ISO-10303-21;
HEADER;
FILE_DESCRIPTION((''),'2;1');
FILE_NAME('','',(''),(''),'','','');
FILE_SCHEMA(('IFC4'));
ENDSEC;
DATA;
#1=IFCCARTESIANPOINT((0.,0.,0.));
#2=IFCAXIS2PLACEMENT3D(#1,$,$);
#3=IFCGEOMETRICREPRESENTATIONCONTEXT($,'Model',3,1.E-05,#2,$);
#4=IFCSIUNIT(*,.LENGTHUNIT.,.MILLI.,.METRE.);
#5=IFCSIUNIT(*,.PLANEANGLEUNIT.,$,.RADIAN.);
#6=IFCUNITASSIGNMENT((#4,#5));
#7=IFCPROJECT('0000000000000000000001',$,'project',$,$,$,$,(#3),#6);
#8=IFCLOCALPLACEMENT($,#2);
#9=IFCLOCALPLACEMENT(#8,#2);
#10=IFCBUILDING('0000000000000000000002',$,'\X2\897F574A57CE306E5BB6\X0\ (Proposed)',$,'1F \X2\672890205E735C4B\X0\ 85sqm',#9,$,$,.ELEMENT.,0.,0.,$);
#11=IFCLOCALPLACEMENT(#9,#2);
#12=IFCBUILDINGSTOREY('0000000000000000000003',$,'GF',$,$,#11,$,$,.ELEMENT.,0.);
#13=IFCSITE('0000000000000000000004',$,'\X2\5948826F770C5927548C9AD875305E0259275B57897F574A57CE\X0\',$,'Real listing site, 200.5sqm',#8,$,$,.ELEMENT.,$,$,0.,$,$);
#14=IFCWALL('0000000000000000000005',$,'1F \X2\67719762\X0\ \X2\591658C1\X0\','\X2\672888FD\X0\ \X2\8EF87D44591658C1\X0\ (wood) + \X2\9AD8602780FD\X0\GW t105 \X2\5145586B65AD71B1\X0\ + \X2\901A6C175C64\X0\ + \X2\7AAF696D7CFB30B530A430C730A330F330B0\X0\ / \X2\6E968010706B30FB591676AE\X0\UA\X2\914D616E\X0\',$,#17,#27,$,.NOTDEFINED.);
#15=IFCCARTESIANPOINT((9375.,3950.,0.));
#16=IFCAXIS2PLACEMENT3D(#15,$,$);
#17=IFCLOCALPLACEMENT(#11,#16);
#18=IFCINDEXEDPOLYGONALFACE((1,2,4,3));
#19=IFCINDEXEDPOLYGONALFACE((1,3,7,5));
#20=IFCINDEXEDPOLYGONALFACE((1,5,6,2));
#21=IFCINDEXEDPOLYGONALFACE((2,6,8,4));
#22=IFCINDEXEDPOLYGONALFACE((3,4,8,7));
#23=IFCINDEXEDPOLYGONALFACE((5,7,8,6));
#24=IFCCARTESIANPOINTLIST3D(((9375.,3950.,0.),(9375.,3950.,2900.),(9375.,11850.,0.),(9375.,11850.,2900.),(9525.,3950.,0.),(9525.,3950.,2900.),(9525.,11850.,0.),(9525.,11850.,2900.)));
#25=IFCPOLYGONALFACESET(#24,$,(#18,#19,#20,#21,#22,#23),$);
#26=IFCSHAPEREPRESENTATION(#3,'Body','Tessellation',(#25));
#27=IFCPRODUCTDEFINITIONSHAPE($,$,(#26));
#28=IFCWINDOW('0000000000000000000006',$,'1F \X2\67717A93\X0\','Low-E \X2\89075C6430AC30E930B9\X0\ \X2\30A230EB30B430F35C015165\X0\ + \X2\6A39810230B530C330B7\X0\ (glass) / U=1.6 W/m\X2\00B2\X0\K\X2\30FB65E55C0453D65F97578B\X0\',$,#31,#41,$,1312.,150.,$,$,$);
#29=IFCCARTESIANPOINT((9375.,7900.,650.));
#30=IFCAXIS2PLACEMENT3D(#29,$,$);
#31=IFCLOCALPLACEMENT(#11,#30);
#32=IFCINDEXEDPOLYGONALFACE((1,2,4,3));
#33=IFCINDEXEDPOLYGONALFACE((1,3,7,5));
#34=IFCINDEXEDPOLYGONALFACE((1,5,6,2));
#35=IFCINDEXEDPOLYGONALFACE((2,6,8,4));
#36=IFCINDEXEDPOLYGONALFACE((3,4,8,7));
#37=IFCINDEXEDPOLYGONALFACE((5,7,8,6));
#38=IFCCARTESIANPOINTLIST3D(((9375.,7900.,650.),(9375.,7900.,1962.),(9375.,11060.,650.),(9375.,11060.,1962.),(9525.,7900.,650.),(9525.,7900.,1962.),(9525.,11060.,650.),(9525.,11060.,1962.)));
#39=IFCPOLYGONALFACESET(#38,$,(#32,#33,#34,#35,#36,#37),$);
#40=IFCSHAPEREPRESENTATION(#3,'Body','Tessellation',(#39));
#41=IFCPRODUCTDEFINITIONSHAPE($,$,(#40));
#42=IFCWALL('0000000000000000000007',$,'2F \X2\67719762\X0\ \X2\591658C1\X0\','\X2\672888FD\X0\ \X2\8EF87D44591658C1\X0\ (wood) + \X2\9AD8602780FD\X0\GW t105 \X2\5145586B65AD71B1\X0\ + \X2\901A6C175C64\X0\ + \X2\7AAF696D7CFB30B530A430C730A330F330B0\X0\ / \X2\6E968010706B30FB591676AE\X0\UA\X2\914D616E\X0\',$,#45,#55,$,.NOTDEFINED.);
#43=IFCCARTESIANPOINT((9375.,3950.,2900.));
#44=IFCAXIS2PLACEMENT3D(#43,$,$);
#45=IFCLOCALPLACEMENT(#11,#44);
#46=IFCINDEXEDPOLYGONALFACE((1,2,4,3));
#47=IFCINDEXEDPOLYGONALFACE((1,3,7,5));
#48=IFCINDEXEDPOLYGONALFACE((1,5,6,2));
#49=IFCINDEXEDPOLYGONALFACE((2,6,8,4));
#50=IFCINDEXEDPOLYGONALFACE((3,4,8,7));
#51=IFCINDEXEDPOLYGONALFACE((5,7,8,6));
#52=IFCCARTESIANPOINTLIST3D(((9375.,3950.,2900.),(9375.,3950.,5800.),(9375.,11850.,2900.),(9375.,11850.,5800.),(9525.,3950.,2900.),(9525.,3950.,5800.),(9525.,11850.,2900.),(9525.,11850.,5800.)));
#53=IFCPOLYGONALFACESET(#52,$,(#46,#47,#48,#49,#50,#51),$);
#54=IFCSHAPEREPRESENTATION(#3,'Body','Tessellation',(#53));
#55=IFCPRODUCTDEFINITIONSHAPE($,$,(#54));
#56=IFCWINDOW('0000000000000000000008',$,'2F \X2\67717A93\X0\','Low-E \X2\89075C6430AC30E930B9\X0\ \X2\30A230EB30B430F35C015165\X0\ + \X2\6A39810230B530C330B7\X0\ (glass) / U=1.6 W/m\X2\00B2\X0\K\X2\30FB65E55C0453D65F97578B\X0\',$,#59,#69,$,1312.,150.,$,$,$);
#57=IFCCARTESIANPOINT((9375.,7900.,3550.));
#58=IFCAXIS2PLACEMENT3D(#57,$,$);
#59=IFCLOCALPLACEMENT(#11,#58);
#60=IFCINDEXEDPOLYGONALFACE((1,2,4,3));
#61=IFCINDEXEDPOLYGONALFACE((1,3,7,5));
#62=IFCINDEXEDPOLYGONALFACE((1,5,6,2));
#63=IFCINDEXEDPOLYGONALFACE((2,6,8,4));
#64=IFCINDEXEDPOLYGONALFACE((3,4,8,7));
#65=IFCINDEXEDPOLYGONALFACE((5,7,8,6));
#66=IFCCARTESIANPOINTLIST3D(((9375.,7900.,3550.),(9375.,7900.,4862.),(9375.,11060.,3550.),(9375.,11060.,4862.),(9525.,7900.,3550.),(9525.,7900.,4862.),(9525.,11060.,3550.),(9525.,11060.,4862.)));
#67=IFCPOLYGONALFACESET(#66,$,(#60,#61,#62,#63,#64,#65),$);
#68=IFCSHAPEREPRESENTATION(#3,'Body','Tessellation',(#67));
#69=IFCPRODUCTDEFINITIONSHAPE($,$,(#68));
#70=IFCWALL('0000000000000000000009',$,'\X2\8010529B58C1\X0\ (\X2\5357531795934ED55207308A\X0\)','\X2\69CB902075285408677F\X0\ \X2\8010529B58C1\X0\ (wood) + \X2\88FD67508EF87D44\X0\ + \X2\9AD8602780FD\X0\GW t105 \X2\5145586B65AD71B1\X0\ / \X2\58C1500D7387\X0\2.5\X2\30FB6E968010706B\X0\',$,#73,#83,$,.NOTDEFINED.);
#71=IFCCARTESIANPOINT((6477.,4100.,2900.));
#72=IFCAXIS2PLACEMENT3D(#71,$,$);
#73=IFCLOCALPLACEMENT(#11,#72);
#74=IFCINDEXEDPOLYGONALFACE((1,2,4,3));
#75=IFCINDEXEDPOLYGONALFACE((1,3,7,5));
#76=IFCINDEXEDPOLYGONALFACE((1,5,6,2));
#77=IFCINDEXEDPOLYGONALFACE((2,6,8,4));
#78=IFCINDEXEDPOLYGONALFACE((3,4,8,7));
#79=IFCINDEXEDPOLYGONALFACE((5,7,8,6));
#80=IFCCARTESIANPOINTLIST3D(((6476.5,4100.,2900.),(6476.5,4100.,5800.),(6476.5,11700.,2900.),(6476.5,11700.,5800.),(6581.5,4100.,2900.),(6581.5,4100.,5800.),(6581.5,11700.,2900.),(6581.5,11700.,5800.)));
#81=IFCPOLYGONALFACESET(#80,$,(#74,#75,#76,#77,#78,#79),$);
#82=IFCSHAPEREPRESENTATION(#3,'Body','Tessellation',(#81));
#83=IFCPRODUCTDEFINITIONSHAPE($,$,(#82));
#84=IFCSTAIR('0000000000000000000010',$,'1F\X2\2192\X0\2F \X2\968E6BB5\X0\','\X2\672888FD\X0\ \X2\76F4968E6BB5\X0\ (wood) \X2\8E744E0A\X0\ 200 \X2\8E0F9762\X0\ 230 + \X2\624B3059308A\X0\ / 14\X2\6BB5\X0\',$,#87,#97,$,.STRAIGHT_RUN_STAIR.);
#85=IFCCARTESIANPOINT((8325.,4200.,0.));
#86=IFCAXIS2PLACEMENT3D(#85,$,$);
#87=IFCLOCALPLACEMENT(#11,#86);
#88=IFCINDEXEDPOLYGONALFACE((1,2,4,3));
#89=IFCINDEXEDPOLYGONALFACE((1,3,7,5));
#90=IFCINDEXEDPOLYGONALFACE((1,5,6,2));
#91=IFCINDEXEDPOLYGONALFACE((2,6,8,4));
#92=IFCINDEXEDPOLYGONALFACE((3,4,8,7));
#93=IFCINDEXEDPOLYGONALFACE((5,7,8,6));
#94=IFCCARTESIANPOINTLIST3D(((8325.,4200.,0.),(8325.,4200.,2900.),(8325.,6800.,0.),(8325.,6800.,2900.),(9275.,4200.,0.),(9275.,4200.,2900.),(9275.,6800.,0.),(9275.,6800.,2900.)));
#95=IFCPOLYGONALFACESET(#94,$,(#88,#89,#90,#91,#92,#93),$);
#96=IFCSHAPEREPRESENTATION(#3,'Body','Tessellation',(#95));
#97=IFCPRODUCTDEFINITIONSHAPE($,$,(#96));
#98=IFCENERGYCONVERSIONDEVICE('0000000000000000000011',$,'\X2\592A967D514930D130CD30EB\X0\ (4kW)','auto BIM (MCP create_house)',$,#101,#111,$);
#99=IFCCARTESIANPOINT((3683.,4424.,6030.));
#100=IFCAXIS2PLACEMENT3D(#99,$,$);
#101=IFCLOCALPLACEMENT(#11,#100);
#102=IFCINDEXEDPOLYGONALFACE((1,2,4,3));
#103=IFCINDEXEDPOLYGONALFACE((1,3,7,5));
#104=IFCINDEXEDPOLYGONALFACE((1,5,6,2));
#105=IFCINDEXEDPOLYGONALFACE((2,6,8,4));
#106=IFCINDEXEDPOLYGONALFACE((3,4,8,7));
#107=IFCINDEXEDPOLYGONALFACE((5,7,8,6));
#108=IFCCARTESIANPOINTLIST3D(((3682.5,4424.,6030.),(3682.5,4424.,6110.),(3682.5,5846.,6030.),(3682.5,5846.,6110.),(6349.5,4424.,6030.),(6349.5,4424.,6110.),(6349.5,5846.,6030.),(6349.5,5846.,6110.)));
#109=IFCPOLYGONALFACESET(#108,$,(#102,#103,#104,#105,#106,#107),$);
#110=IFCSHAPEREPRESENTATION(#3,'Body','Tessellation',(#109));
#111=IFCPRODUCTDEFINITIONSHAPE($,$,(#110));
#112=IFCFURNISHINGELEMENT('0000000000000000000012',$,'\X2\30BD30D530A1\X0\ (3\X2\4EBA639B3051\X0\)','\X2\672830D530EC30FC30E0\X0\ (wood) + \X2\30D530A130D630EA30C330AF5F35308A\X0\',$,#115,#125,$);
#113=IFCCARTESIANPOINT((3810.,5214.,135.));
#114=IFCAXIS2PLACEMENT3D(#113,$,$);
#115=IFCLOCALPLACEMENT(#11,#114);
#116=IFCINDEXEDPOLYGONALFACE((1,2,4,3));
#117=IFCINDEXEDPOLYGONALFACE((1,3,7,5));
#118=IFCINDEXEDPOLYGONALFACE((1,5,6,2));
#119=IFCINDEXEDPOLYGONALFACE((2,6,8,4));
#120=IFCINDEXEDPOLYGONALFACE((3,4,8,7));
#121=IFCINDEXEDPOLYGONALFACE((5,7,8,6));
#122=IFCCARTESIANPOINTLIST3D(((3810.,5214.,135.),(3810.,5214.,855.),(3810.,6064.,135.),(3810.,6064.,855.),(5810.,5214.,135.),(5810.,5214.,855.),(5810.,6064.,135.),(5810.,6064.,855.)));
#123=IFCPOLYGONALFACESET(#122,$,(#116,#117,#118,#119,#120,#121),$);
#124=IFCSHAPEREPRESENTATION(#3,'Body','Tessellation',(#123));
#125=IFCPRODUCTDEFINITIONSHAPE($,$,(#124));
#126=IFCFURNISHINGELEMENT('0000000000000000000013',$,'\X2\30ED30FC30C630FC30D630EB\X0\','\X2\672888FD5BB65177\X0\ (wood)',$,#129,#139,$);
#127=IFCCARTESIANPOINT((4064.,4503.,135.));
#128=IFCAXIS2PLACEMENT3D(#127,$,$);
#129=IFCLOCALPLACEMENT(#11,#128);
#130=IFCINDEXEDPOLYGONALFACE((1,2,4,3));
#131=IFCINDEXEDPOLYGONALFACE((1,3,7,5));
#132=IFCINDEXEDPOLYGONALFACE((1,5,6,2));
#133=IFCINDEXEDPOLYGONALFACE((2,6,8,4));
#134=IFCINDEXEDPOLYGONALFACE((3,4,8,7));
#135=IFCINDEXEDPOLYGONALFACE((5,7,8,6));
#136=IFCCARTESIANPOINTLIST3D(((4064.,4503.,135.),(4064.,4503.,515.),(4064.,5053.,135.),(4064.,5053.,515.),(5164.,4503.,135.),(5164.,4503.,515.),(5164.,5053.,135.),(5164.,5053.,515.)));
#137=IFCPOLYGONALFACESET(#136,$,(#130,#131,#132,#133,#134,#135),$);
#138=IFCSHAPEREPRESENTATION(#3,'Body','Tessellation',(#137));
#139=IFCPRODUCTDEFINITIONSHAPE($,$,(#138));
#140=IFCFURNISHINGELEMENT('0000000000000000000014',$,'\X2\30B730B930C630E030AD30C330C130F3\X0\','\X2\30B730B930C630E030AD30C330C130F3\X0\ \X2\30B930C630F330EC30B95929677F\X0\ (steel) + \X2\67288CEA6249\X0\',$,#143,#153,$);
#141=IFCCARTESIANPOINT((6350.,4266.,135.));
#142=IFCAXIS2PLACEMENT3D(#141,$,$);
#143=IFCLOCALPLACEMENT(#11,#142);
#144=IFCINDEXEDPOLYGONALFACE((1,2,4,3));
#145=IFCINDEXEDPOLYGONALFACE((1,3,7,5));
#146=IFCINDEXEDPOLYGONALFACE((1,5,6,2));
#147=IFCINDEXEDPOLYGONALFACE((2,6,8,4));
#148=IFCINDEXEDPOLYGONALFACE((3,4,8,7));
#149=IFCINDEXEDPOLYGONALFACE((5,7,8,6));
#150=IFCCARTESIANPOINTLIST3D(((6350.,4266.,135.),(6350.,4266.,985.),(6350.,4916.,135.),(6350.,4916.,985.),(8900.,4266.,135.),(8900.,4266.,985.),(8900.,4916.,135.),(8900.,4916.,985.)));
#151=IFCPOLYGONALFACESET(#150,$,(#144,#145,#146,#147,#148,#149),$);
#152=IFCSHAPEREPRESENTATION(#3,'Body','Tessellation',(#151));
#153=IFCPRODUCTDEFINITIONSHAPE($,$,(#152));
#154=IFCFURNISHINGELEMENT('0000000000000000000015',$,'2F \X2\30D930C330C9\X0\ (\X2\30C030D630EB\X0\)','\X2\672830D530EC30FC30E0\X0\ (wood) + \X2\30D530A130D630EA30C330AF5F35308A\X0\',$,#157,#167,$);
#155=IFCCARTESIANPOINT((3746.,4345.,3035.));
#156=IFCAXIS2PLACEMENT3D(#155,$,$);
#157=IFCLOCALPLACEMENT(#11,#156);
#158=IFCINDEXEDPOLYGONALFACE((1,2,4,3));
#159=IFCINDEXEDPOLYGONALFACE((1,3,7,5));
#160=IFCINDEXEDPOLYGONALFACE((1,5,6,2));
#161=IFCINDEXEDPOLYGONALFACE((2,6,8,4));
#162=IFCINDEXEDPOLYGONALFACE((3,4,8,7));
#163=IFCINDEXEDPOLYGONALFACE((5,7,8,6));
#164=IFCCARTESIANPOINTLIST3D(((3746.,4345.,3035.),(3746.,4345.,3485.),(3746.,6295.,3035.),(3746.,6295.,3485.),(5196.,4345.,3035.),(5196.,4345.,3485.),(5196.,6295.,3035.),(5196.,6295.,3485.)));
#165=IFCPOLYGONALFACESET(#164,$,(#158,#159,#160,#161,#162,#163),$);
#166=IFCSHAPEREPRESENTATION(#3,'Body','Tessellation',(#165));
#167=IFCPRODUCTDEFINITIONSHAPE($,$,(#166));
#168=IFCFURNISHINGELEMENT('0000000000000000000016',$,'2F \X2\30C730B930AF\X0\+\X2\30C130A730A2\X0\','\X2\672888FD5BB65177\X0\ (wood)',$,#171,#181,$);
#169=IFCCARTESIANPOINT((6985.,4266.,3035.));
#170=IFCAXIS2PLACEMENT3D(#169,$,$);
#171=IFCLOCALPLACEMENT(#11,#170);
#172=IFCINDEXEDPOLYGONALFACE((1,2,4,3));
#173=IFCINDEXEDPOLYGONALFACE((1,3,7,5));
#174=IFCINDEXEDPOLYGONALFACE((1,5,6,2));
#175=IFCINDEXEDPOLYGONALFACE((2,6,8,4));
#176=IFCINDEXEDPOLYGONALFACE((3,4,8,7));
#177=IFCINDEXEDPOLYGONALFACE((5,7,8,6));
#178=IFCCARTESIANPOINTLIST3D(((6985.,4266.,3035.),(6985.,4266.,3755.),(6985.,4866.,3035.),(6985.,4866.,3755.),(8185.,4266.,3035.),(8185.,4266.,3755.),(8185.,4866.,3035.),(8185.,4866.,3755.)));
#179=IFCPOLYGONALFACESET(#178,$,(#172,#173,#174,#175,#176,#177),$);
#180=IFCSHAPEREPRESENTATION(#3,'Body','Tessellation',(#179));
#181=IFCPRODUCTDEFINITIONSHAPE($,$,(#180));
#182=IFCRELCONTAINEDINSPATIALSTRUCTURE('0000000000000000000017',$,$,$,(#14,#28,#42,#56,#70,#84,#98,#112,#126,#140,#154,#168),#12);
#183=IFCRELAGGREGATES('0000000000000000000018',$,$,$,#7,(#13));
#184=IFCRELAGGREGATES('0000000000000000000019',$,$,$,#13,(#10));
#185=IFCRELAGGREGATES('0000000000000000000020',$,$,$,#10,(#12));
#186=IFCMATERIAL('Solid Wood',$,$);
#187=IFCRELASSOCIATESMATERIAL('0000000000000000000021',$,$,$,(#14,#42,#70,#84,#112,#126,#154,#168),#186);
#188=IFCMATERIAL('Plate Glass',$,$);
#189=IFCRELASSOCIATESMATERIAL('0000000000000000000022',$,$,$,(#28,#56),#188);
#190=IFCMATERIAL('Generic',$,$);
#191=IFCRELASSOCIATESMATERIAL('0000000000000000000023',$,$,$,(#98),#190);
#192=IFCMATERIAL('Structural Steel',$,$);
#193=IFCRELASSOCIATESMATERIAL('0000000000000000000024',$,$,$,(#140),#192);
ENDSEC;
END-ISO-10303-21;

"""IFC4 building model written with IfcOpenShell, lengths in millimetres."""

from ifc_helpers import new_model, si_unit, frame, frame_2d, origin, place, context, project, spatial, rectangle, extrude, material, element, fill, save


model = new_model("IFC4")

# Units and contexts
model_context = context("Model", 3, precision=1e-05, world=origin())
ifc_project = project(units=[si_unit("LENGTHUNIT", "METRE", prefix="MILLI"), si_unit("PLANEANGLEUNIT", "RADIAN")], contexts=[model_context])

# Site, building, storey
site_placement = place(None, origin())
site = spatial("IfcSite", under=ifc_project, at=site_placement, Name="奈良県大和高田市大字西坊城", ObjectType="Real listing site, 200.5sqm", CompositionType="ELEMENT", RefElevation=0.0)
building_placement = place(site_placement, origin())
building = spatial("IfcBuilding", under=site, at=building_placement, Name="西坊城の家 (Proposed)", ObjectType="1F 木造平屋 85sqm", CompositionType="ELEMENT", ElevationOfRefHeight=0.0, ElevationOfTerrain=0.0)
storey_placement = place(building_placement, origin())
storey = spatial("IfcBuildingStorey", under=building, at=storey_placement, Name="GF", CompositionType="ELEMENT", Elevation=0.0)

# Wall, opening, window
ifc_material_1 = material(Name="Solid Wood")
wall_1_placement = place(storey_placement, frame((9375.0, 3950.0, 0.0)))
wall_1 = element("IfcWall", 1, at=wall_1_placement, inside=storey, material=ifc_material_1, Name="1F 東面 外壁", Description="木製 軸組外壁 (wood) + 高性能GW t105 充填断熱 + 通気層 + 窯業系サイディング / 準耐火・外皮UA配慮", PredefinedType="NOTDEFINED", context=model_context, shape_type="SweptSolid", body=[
    extrude(rectangle(XDim=150.0, YDim=7900.0, at=frame_2d((75.0, 3950.0))), frame((9375.0, 3950.0, 0.0)), (0.0, 0.0, 1.0), 2900.0),
])
opening_1_placement = place(storey_placement, frame((9375.0, 7900.0, 650.0)))
opening_1 = element("IfcOpeningElement", 2, at=opening_1_placement, cuts=wall_1, PredefinedType="NOTDEFINED", context=model_context, shape_type="SweptSolid", body=[
    extrude(rectangle(XDim=150.0, YDim=3160.0, at=frame_2d((75.0, 1580.0))), frame((9375.0, 7900.0, 650.0)), (0.0, 0.0, 1.0), 1312.0),
])
ifc_material_2 = material(Name="Plate Glass")
window_1_placement = place(storey_placement, frame((9375.0, 7900.0, 650.0)))
window_1 = element("IfcWindow", 3, at=window_1_placement, inside=storey, material=ifc_material_2, Name="1F 東窓", Description="Low-E 複層ガラス アルゴン封入 + 樹脂サッシ (glass) / U=1.6 W/m²K・日射取得型", OverallHeight=1312.0, OverallWidth=150.0, context=model_context, shape_type="SweptSolid", body=[
    extrude(rectangle(XDim=150.0, YDim=3160.0, at=frame_2d((75.0, 1580.0))), frame((9375.0, 7900.0, 650.0)), (0.0, 0.0, 1.0), 1312.0),
])
fill(opening_1, window_1)

# Wall, opening, window
wall_2_placement = place(storey_placement, frame((9375.0, 3950.0, 2900.0)))
wall_2 = element("IfcWall", 4, at=wall_2_placement, inside=storey, material=ifc_material_1, Name="2F 東面 外壁", Description="木製 軸組外壁 (wood) + 高性能GW t105 充填断熱 + 通気層 + 窯業系サイディング / 準耐火・外皮UA配慮", PredefinedType="NOTDEFINED", context=model_context, shape_type="SweptSolid", body=[
    extrude(rectangle(XDim=150.0, YDim=7900.0, at=frame_2d((75.0, 3950.0))), frame((9375.0, 3950.0, 2900.0)), (0.0, 0.0, 1.0), 2900.0),
])
opening_2_placement = place(storey_placement, frame((9375.0, 7900.0, 3550.0)))
opening_2 = element("IfcOpeningElement", 5, at=opening_2_placement, cuts=wall_2, PredefinedType="NOTDEFINED", context=model_context, shape_type="SweptSolid", body=[
    extrude(rectangle(XDim=150.0, YDim=3160.0, at=frame_2d((75.0, 1580.0))), frame((9375.0, 7900.0, 3550.0)), (0.0, 0.0, 1.0), 1312.0),
])
window_2_placement = place(storey_placement, frame((9375.0, 7900.0, 3550.0)))
window_2 = element("IfcWindow", 6, at=window_2_placement, inside=storey, material=ifc_material_2, Name="2F 東窓", Description="Low-E 複層ガラス アルゴン封入 + 樹脂サッシ (glass) / U=1.6 W/m²K・日射取得型", OverallHeight=1312.0, OverallWidth=150.0, context=model_context, shape_type="SweptSolid", body=[
    extrude(rectangle(XDim=150.0, YDim=3160.0, at=frame_2d((75.0, 1580.0))), frame((9375.0, 7900.0, 3550.0)), (0.0, 0.0, 1.0), 1312.0),
])
fill(opening_2, window_2)

# Wall
wall_3_placement = place(storey_placement, frame((6477.0, 4100.0, 2900.0)))
element("IfcWall", 7, at=wall_3_placement, inside=storey, material=ifc_material_1, Name="耐力壁 (南北間仕切り)", Description="構造用合板 耐力壁 (wood) + 製材軸組 + 高性能GW t105 充填断熱 / 壁倍率2.5・準耐火", PredefinedType="NOTDEFINED", context=model_context, shape_type="SweptSolid", body=[
    extrude(rectangle(XDim=105.0, YDim=7600.0, at=frame_2d((52.0, 3800.0))), frame((6477.0, 4100.0, 2900.0)), (0.0, 0.0, 1.0), 2900.0),
])

# Stair
stair_placement = place(storey_placement, frame((8325.0, 4200.0, 0.0)))
element("IfcStair", 8, at=stair_placement, inside=storey, material=ifc_material_1, Name="1F→2F 階段", Description="木製 直階段 (wood) 蹴上 200 踏面 230 + 手すり / 14段", PredefinedType="STRAIGHT_RUN_STAIR", context=model_context, shape_type="SweptSolid", body=[
    extrude(rectangle(XDim=950.0, YDim=2600.0, at=frame_2d((475.0, 1300.0))), frame((8325.0, 4200.0, 0.0)), (0.0, 0.0, 1.0), 2900.0),
])

# Energy conversion device
ifc_material_3 = material(Name="Generic")
energy_conversion_device_placement = place(storey_placement, frame((3683.0, 4424.0, 6030.0)))
element("IfcEnergyConversionDevice", 9, at=energy_conversion_device_placement, inside=storey, material=ifc_material_3, Name="太陽光パネル (4kW)", Description="auto BIM (MCP create_house)", context=model_context, shape_type="SweptSolid", body=[
    extrude(rectangle(XDim=2667.0, YDim=1422.0, at=frame_2d((1333.0, 711.0))), frame((3683.0, 4424.0, 6030.0)), (0.0, 0.0, 1.0), 80.0),
])

# Furnishing elements
furnishing_1_placement = place(storey_placement, frame((3810.0, 5214.0, 135.0)))
element("IfcFurnishingElement", 10, at=furnishing_1_placement, inside=storey, material=ifc_material_1, Name="ソファ (3人掛け)", Description="木フレーム (wood) + ファブリック張り", context=model_context, shape_type="SweptSolid", body=[
    extrude(rectangle(XDim=2000.0, YDim=850.0, at=frame_2d((1000.0, 425.0))), frame((3810.0, 5214.0, 135.0)), (0.0, 0.0, 1.0), 720.0),
])
furnishing_2_placement = place(storey_placement, frame((4064.0, 4503.0, 135.0)))
element("IfcFurnishingElement", 11, at=furnishing_2_placement, inside=storey, material=ifc_material_1, Name="ローテーブル", Description="木製家具 (wood)", context=model_context, shape_type="SweptSolid", body=[
    extrude(rectangle(XDim=1100.0, YDim=550.0, at=frame_2d((550.0, 275.0))), frame((4064.0, 4503.0, 135.0)), (0.0, 0.0, 1.0), 380.0),
])
ifc_material_4 = material(Name="Structural Steel")
furnishing_3_placement = place(storey_placement, frame((6350.0, 4266.0, 135.0)))
element("IfcFurnishingElement", 12, at=furnishing_3_placement, inside=storey, material=ifc_material_4, Name="システムキッチン", Description="システムキッチン ステンレス天板 (steel) + 木質扉", context=model_context, shape_type="SweptSolid", body=[
    extrude(rectangle(XDim=2550.0, YDim=650.0, at=frame_2d((1275.0, 325.0))), frame((6350.0, 4266.0, 135.0)), (0.0, 0.0, 1.0), 850.0),
])
furnishing_4_placement = place(storey_placement, frame((3746.0, 4345.0, 3035.0)))
element("IfcFurnishingElement", 13, at=furnishing_4_placement, inside=storey, material=ifc_material_1, Name="2F ベッド (ダブル)", Description="木フレーム (wood) + ファブリック張り", context=model_context, shape_type="SweptSolid", body=[
    extrude(rectangle(XDim=1450.0, YDim=1950.0, at=frame_2d((725.0, 975.0))), frame((3746.0, 4345.0, 3035.0)), (0.0, 0.0, 1.0), 450.0),
])
furnishing_5_placement = place(storey_placement, frame((6985.0, 4266.0, 3035.0)))
element("IfcFurnishingElement", 14, at=furnishing_5_placement, inside=storey, material=ifc_material_1, Name="2F デスク+チェア", Description="木製家具 (wood)", context=model_context, shape_type="SweptSolid", body=[
    extrude(rectangle(XDim=1200.0, YDim=600.0, at=frame_2d((600.0, 300.0))), frame((6985.0, 4266.0, 3035.0)), (0.0, 0.0, 1.0), 720.0),
])

save(model, "model.ifc")
